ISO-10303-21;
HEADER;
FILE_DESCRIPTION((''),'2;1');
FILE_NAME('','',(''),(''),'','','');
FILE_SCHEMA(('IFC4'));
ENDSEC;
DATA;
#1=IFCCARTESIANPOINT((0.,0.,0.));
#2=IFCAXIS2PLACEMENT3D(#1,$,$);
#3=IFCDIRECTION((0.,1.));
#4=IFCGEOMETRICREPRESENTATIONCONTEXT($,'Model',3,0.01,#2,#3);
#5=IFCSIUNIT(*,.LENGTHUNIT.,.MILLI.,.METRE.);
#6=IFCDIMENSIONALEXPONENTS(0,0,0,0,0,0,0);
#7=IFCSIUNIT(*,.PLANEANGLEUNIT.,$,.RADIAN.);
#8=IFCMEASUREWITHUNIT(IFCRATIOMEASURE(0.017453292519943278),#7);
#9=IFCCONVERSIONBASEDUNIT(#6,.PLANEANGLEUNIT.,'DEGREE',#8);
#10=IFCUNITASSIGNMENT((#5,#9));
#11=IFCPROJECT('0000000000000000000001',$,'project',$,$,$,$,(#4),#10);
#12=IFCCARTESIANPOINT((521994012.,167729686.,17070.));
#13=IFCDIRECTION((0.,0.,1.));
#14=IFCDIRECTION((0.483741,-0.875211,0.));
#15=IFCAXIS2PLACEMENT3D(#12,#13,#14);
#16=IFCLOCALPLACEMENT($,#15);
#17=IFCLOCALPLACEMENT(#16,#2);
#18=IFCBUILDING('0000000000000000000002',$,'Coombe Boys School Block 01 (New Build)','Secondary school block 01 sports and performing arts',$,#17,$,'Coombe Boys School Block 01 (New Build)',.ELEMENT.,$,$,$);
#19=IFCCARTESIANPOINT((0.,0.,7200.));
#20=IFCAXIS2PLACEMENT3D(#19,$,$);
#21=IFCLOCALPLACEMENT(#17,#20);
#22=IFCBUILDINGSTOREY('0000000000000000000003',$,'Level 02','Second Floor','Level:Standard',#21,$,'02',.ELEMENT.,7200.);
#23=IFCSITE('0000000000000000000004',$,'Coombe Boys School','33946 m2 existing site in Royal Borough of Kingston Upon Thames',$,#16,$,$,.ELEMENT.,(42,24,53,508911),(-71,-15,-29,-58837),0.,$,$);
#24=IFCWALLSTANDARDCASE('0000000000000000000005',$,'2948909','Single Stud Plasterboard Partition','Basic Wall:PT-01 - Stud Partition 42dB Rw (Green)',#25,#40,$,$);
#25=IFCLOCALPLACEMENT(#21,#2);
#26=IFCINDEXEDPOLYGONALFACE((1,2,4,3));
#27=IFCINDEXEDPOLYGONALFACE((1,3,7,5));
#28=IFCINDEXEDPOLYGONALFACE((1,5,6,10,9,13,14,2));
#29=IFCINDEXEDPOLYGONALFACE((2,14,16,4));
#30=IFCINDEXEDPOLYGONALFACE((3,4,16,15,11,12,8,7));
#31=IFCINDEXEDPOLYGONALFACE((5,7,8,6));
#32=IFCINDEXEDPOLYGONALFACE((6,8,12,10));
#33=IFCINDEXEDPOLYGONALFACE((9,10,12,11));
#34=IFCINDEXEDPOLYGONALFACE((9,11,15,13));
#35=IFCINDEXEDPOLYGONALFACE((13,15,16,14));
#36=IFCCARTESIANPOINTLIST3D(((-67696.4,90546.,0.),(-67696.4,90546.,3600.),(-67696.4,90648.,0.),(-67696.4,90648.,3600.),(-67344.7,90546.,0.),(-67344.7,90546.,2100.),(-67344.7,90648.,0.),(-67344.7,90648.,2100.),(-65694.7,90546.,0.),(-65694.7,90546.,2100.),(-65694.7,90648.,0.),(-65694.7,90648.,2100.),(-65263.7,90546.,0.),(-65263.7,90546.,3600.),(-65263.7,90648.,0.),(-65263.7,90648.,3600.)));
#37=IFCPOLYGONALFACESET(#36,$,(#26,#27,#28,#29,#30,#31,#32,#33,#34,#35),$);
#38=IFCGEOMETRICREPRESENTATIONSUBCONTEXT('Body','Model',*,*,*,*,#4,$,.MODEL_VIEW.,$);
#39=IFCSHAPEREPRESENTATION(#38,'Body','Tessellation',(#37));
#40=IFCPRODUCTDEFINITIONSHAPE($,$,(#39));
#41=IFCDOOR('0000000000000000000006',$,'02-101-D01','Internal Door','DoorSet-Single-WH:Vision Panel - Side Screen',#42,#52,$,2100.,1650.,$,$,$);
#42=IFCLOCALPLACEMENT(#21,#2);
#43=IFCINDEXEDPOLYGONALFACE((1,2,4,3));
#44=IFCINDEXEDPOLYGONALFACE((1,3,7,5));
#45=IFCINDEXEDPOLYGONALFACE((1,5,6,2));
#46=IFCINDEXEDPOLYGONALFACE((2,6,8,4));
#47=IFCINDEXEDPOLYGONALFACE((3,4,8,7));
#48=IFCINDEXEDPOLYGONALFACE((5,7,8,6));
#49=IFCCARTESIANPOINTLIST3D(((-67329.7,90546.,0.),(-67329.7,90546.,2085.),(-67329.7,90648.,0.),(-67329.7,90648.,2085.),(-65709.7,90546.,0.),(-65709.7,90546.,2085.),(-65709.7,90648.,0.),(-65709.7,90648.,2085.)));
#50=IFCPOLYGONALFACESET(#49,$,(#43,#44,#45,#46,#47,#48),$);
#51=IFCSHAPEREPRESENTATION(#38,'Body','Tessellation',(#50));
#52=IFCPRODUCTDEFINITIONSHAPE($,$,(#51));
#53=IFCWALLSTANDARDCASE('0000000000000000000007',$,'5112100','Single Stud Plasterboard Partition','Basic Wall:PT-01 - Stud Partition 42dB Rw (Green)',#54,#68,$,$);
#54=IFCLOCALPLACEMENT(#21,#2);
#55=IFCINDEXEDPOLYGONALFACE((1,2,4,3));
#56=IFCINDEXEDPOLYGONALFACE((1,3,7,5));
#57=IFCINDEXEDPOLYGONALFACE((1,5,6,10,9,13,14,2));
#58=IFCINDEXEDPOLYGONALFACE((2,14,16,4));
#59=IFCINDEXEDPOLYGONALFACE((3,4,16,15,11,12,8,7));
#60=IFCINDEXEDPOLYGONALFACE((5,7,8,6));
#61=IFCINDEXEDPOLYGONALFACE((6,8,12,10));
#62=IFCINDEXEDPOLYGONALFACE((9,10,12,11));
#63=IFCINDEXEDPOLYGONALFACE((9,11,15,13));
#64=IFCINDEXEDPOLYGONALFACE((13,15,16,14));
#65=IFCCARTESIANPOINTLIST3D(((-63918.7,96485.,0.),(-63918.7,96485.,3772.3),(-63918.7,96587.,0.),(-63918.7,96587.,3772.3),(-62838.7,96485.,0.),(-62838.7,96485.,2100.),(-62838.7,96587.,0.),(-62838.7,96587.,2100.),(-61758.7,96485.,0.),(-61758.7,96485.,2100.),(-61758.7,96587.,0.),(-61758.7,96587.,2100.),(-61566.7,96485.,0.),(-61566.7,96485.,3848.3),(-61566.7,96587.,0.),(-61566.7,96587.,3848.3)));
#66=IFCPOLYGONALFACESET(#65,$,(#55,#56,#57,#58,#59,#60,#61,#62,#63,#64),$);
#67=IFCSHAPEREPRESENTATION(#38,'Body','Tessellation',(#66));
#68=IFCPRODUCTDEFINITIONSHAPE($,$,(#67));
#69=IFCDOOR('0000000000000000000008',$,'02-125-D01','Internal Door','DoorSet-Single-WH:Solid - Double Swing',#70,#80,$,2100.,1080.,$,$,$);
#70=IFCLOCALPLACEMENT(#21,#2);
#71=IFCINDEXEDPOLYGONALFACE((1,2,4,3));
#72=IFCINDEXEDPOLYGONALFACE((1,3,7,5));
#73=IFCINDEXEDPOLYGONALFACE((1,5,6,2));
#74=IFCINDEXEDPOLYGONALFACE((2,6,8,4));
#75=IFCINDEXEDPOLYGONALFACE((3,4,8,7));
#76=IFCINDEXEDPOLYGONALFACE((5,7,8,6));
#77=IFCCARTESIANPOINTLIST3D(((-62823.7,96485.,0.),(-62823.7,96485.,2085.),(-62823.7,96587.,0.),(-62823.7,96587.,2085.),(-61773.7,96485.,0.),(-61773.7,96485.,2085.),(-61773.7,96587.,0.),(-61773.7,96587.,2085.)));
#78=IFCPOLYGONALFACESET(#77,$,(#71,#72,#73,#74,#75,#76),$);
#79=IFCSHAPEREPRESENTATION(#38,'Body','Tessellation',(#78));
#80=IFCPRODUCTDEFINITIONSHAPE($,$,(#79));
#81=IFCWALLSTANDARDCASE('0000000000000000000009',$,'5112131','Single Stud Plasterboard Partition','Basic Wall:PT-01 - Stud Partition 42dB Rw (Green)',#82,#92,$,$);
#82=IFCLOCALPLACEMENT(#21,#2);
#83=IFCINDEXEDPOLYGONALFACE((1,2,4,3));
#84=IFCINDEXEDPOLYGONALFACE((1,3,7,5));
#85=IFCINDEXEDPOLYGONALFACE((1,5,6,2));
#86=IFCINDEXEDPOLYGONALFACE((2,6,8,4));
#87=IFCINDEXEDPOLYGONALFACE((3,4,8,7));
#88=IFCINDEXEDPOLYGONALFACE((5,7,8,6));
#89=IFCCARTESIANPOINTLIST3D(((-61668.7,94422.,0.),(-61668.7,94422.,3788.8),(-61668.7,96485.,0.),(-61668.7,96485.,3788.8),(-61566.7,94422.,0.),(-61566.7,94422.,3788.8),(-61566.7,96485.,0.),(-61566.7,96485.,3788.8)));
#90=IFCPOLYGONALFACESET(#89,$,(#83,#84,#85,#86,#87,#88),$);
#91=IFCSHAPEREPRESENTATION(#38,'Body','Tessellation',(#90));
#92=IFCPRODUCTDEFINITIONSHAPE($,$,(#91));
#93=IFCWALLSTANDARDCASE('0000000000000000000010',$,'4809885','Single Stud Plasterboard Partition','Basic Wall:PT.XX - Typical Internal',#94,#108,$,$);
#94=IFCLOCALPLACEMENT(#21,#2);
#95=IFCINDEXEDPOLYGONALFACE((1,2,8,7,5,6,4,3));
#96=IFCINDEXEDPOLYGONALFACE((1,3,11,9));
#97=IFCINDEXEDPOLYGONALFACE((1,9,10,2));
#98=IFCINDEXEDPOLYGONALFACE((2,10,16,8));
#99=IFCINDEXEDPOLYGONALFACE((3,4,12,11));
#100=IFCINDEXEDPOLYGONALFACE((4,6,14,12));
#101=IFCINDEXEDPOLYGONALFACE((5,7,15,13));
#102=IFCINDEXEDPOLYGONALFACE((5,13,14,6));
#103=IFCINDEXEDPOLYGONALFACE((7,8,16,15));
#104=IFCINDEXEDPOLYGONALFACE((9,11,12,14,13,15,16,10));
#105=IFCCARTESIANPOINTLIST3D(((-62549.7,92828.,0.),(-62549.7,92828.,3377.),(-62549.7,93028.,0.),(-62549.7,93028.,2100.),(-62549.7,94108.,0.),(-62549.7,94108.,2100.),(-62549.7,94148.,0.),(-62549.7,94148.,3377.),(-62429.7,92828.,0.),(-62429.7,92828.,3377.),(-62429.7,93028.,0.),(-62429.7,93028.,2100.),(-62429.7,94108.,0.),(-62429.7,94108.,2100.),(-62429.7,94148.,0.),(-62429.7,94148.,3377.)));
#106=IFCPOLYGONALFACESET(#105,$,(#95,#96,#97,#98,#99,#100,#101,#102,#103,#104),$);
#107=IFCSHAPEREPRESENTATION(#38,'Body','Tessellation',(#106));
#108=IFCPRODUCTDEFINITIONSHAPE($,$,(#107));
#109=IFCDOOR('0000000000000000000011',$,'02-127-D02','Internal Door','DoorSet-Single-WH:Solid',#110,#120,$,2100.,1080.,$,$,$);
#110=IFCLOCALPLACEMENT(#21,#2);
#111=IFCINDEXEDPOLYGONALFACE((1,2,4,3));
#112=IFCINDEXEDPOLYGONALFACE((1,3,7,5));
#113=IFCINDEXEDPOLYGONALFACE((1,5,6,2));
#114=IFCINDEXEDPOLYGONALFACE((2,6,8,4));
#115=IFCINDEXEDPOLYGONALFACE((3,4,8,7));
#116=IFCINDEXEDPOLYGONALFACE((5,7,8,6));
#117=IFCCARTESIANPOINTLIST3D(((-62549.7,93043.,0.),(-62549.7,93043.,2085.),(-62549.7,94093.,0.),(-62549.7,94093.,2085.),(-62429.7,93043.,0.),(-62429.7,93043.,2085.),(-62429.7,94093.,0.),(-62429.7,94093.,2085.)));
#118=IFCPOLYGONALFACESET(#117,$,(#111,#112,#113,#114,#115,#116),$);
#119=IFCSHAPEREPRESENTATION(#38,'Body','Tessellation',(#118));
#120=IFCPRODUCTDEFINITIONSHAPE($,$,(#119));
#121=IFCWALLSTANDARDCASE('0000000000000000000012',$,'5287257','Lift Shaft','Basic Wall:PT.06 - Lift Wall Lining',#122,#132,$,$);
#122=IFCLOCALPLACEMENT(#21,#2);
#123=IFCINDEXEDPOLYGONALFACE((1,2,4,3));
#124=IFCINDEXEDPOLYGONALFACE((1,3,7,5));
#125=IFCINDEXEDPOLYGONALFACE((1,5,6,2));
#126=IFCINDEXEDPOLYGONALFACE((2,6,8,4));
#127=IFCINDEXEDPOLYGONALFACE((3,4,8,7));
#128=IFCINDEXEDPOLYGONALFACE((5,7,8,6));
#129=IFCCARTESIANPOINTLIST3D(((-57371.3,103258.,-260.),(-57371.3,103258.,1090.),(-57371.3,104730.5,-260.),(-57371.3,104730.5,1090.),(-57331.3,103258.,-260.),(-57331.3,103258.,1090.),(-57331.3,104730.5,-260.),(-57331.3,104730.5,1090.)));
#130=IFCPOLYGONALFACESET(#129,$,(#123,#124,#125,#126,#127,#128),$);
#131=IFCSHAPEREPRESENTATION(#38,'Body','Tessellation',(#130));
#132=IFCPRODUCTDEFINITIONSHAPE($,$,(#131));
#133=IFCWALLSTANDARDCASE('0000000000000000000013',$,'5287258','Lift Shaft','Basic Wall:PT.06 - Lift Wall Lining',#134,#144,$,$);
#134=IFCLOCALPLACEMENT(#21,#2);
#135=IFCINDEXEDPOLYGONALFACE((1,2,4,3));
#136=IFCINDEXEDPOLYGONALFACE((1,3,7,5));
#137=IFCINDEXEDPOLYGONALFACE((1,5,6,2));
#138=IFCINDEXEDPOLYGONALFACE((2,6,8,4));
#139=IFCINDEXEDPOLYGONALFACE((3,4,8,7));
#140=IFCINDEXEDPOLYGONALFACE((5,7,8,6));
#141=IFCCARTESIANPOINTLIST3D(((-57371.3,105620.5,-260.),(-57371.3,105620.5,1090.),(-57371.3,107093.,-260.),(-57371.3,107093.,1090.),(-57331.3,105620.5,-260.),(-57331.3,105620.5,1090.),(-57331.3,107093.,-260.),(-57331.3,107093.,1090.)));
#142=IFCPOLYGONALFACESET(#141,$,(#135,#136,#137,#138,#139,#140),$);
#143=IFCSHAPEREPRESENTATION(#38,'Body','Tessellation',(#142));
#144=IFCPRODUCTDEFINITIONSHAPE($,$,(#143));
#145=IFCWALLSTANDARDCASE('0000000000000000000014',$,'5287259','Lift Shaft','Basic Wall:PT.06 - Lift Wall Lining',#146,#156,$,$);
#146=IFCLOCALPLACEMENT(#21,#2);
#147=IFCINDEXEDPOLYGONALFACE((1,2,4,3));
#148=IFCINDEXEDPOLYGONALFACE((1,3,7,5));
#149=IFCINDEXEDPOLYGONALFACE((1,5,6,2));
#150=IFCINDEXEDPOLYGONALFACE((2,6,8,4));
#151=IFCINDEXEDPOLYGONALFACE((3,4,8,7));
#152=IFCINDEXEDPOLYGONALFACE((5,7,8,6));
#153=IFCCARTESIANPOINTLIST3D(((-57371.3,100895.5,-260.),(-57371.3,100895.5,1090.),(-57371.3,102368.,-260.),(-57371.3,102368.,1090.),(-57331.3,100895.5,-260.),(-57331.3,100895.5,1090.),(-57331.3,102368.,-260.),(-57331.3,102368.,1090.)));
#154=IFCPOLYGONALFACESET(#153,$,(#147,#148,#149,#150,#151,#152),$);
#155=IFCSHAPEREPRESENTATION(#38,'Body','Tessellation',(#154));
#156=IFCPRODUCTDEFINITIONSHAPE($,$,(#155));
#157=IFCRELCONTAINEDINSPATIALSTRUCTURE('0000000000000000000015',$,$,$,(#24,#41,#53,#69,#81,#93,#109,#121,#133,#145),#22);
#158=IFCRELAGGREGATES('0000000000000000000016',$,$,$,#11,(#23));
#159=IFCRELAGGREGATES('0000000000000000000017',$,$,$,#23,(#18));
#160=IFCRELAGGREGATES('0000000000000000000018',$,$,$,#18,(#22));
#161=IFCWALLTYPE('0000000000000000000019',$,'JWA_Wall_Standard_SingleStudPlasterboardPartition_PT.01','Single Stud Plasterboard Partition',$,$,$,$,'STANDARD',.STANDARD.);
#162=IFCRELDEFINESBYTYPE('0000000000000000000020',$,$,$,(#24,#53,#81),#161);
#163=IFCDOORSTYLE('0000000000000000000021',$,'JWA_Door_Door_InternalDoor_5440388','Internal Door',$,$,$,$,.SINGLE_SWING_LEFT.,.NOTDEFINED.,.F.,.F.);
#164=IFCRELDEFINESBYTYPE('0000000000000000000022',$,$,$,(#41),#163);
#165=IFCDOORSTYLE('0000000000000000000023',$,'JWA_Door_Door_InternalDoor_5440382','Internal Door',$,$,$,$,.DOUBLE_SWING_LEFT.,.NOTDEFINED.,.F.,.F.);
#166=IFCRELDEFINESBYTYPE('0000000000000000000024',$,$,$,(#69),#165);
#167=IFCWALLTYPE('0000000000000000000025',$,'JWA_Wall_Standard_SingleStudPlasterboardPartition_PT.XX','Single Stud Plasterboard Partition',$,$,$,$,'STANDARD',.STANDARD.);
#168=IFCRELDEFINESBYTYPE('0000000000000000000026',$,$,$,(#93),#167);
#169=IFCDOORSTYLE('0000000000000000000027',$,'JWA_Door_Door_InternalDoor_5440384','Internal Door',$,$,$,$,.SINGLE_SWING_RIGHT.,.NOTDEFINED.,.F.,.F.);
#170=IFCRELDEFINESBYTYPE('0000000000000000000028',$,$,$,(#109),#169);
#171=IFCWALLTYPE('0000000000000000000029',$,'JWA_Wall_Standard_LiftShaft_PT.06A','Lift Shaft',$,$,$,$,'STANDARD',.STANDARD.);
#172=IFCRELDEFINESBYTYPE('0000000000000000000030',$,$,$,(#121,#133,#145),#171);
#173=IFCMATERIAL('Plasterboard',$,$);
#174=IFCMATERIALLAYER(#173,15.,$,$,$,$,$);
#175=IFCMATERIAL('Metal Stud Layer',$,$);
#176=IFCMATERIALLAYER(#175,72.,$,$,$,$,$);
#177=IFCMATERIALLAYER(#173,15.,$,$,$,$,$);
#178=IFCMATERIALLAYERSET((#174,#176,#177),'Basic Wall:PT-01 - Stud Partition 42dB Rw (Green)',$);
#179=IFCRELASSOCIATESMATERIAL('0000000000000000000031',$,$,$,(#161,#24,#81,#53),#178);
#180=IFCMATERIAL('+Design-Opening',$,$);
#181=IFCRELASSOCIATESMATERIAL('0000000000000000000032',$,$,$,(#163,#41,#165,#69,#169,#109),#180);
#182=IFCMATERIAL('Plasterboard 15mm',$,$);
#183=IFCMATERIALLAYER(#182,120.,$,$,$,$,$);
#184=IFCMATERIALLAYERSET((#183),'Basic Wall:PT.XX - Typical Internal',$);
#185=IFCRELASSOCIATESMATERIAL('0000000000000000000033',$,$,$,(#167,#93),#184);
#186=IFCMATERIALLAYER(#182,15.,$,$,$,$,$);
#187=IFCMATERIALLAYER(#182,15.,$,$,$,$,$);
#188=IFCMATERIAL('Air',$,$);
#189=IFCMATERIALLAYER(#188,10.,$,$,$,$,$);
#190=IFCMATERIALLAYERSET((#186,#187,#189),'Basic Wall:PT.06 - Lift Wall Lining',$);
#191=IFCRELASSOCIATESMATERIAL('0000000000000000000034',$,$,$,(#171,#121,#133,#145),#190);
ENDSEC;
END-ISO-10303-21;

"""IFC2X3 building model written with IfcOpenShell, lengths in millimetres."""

from ifc_helpers import new_model, entity, si_unit, converted_unit, direction, frame, frame_2d, origin, origin_2d_with_axis, place, context, subcontext, project, spatial, polyline, rectangle, extrude, clip, bounded_halfspace, source, transform, mapped, material, layer, layer_set, layer_usage, type_object, type_shapes, element, fill, save


model = new_model("IFC2X3")

# Units and contexts
model_context = context("Model", 3, precision=0.01, world=origin(), true_north=direction((0.0, 1.0)))
body_context = subcontext(model_context, "Body", "Model", "MODEL_VIEW")
ifc_project = project(units=[si_unit("LENGTHUNIT", "METRE", prefix="MILLI"), converted_unit("PLANEANGLEUNIT", "DEGREE", entity("IfcRatioMeasure", 0.017453292519943278), si_unit("PLANEANGLEUNIT", "RADIAN"), dimensions=[0, 0, 0, 0, 0, 0, 0])], contexts=[model_context])

# Site, building, storey
site_placement = place(None, frame((521994012.0, 167729686.0, 17070.0), z_axis=(0.0, 0.0, 1.0), x_axis=(0.483741, -0.875211, 0.0)))
site = spatial("IfcSite", under=ifc_project, at=site_placement, Name="Coombe Boys School", Description="33946 m2 existing site in Royal Borough of Kingston Upon Thames", CompositionType="ELEMENT", RefLatitude=(42, 24, 53, 508911), RefLongitude=(-71, -15, -29, -58837), RefElevation=0.0)
building_placement = place(site_placement, origin())
building = spatial("IfcBuilding", under=site, at=building_placement, Name="Coombe Boys School Block 01 (New Build)", Description="Secondary school block 01 sports and performing arts", LongName="Coombe Boys School Block 01 (New Build)", CompositionType="ELEMENT")
storey_placement = place(building_placement, frame((0.0, 0.0, 7200.0)))
storey = spatial("IfcBuildingStorey", under=building, at=storey_placement, Name="Level 02", Description="Second Floor", ObjectType="Level:Standard", LongName="02", CompositionType="ELEMENT", Elevation=7200.0)

# Walls, openings, doors
ifc_material_1 = material(Name="Plasterboard")
ifc_layer_1 = layer(ifc_material_1, 15.0)
ifc_material_2 = material(Name="Metal Stud Layer")
ifc_layer_2 = layer(ifc_material_2, 72.0)
ifc_layer_3 = layer(ifc_material_1, 15.0)
ifc_layer_set_1 = layer_set([ifc_layer_1, ifc_layer_2, ifc_layer_3], Name="Basic Wall:PT-01 - Stud Partition 42dB Rw (Green)")
ifc_layer_usage_1 = layer_usage(ifc_layer_set_1, "AXIS2", "NEGATIVE", 51.0)
wall_type_1 = type_object("IfcWallType", Name="JWA_Wall_Standard_SingleStudPlasterboardPartition_PT.01", Description="Single Stud Plasterboard Partition", ElementType="STANDARD", PredefinedType="STANDARD", material=ifc_layer_set_1)
wall_1_placement = place(storey_placement, frame((-65263.7, 90597.0, 0.0), z_axis=(0.0, 0.0, 1.0), x_axis=(-1.0, 0.0, 0.0)))
wall_1 = element("IfcWallStandardCase", 1, at=wall_1_placement, inside=storey, type_object=wall_type_1, material=ifc_layer_usage_1, Name="2948909", Description="Single Stud Plasterboard Partition", ObjectType="Basic Wall:PT-01 - Stud Partition 42dB Rw (Green)", context=body_context, shape_type="SweptSolid", body=[
    extrude(rectangle(XDim=2432.7, YDim=102.0, at=frame_2d((1216.3, 0.0), x_axis=(-1.0, 0.0))), origin(), (0.0, 0.0, 1.0), 3600.0),
])
opening_1_placement = place(wall_1_placement, frame((-65263.7, 90597.0, 0.0), z_axis=(0.0, 0.0, 1.0), x_axis=(-1.0, 0.0, 0.0)))
opening_1 = element("IfcOpeningElement", 2, at=opening_1_placement, cuts=wall_1, ObjectType="Opening", context=body_context, shape_type="SweptSolid", body=[
    extrude(rectangle(XDim=2100.0, YDim=1650.0, at=frame_2d((0.0, 0.0), x_axis=(0.0, 1.0))), frame((-66519.7, 90648.0, 1050.0), z_axis=(0.0, -1.0, 0.0), x_axis=(-1.0, 0.0, 0.0)), (0.0, 0.0, 1.0), 102.0),
])
ifc_material_3 = material(Name="+Design-Opening")
door_style_1 = type_object("IfcDoorStyle", Name="JWA_Door_Door_InternalDoor_5440388", Description="Internal Door", ConstructionType="NOTDEFINED", OperationType="SINGLE_SWING_LEFT", ParameterTakesPrecedence=False, Sizeable=False, material=ifc_material_3)
shared_shape_1 = source(origin(), body_context, "Body", "SweptSolid", [
    extrude(rectangle(XDim=1620.0, YDim=102.0, at=origin_2d_with_axis()), frame((-160.0, 0.0, 0.0), z_axis=(0.0, 0.0, 1.0), x_axis=(-1.0, 0.0, 0.0)), (0.0, 0.0, 1.0), 2085.0),
])
type_shapes(door_style_1, [shared_shape_1])
door_1_placement = place(opening_1_placement, frame((-66359.7, 90597.0, 0.0)))
door_1 = element("IfcDoor", 3, at=door_1_placement, inside=storey, type_object=door_style_1, material=ifc_material_3, Name="02-101-D01", Description="Internal Door", ObjectType="DoorSet-Single-WH:Vision Panel - Side Screen", OverallHeight=2100.0, OverallWidth=1650.0, context=body_context, shape_type="MappedRepresentation", body=[
    mapped(shared_shape_1, transform((0.0, 0.0, 0.0), scale=1.0)),
])
fill(opening_1, door_1)
ifc_layer_usage_2 = layer_usage(ifc_layer_set_1, "AXIS2", "POSITIVE", -51.0)
wall_2_placement = place(storey_placement, frame((-61566.7, 96536.0, 0.0), z_axis=(0.0, 0.0, 1.0), x_axis=(-1.0, 0.0, 0.0)))
wall_2 = element("IfcWallStandardCase", 4, at=wall_2_placement, inside=storey, type_object=wall_type_1, material=ifc_layer_usage_2, Name="5112100", Description="Single Stud Plasterboard Partition", ObjectType="Basic Wall:PT-01 - Stud Partition 42dB Rw (Green)", context=body_context, shape_type="Clipping", body=[
    clip(extrude(rectangle(XDim=2352.0, YDim=102.0, at=frame_2d((1176.0, 0.0), x_axis=(1.0, 0.0))), origin(), (0.0, 0.0, 1.0), 3848.3), bounded_halfspace(frame((0.0, -51.0, 3848.3), z_axis=(0.032283, 0.0, 0.999479), x_axis=(0.0, 1.0, 0.0)), False, frame((0.0, -51.0, 3848.3)), polyline([(0.0, 0.0), (2352.0, 0.0), (2352.0, 102.0), (0.0, 102.0), (0.0, 0.0)]))),
])
opening_2_placement = place(wall_2_placement, frame((-61566.7, 96536.0, 0.0), z_axis=(0.0, 0.0, 1.0), x_axis=(-1.0, 0.0, 0.0)))
opening_2 = element("IfcOpeningElement", 5, at=opening_2_placement, cuts=wall_2, ObjectType="Opening", context=body_context, shape_type="SweptSolid", body=[
    extrude(rectangle(XDim=2100.0, YDim=1080.0, at=frame_2d((0.0, 0.0), x_axis=(0.0, 1.0))), frame((-62298.7, 96587.0, 1050.0), z_axis=(0.0, -1.0, 0.0), x_axis=(-1.0, 0.0, 0.0)), (0.0, 0.0, 1.0), 102.0),
])
door_style_2 = type_object("IfcDoorStyle", Name="JWA_Door_Door_InternalDoor_5440382", Description="Internal Door", ConstructionType="NOTDEFINED", OperationType="DOUBLE_SWING_LEFT", ParameterTakesPrecedence=False, Sizeable=False, material=ifc_material_3)
shared_shape_2 = source(origin(), body_context, "Body", "SweptSolid", [
    extrude(rectangle(XDim=1050.0, YDim=102.0, at=origin_2d_with_axis()), frame((125.0, 0.0, 0.0), z_axis=(0.0, 0.0, 1.0), x_axis=(-1.0, 0.0, 0.0)), (0.0, 0.0, 1.0), 2085.0),
])
type_shapes(door_style_2, [shared_shape_2])
door_2_placement = place(opening_2_placement, frame((-62423.7, 96536.0, 0.0)))
door_2 = element("IfcDoor", 6, at=door_2_placement, inside=storey, type_object=door_style_2, material=ifc_material_3, Name="02-125-D01", Description="Internal Door", ObjectType="DoorSet-Single-WH:Solid - Double Swing", OverallHeight=2100.0, OverallWidth=1080.0, context=body_context, shape_type="MappedRepresentation", body=[
    mapped(shared_shape_2, transform((0.0, 0.0, 0.0), scale=1.0)),
])
fill(opening_2, door_2)

# Wall
wall_3_placement = place(storey_placement, frame((-61617.7, 96485.0, 0.0), z_axis=(0.0, 0.0, 1.0), x_axis=(0.0, -1.0, 0.0)))
element("IfcWallStandardCase", 7, at=wall_3_placement, inside=storey, type_object=wall_type_1, material=ifc_layer_usage_1, Name="5112131", Description="Single Stud Plasterboard Partition", ObjectType="Basic Wall:PT-01 - Stud Partition 42dB Rw (Green)", context=body_context, shape_type="SweptSolid", body=[
    extrude(rectangle(XDim=2063.0, YDim=102.0, at=frame_2d((1031.5, 0.0), x_axis=(-1.0, 0.0))), origin(), (0.0, 0.0, 1.0), 3788.8),
])

# Wall, opening, door
ifc_material_4 = material(Name="Plasterboard 15mm")
ifc_layer_4 = layer(ifc_material_4, 120.0)
ifc_layer_set_2 = layer_set([ifc_layer_4], Name="Basic Wall:PT.XX - Typical Internal")
ifc_layer_usage_3 = layer_usage(ifc_layer_set_2, "AXIS2", "NEGATIVE", 60.0)
wall_type_2 = type_object("IfcWallType", Name="JWA_Wall_Standard_SingleStudPlasterboardPartition_PT.XX", Description="Single Stud Plasterboard Partition", ElementType="STANDARD", PredefinedType="STANDARD", material=ifc_layer_set_2)
wall_4_placement = place(storey_placement, frame((-62489.7, 94148.0, 0.0), z_axis=(0.0, 0.0, 1.0), x_axis=(0.0, -1.0, 0.0)))
wall_4 = element("IfcWallStandardCase", 8, at=wall_4_placement, inside=storey, type_object=wall_type_2, material=ifc_layer_usage_3, Name="4809885", Description="Single Stud Plasterboard Partition", ObjectType="Basic Wall:PT.XX - Typical Internal", context=body_context, shape_type="SweptSolid", body=[
    extrude(rectangle(XDim=1320.0, YDim=120.0, at=frame_2d((660.0, 0.0), x_axis=(-1.0, 0.0))), origin(), (0.0, 0.0, 1.0), 3377.0),
])
opening_3_placement = place(wall_4_placement, frame((94148.0, 62489.7, 0.0), z_axis=(0.0, 0.0, 1.0), x_axis=(0.0, 1.0, 0.0)))
opening_3 = element("IfcOpeningElement", 9, at=opening_3_placement, cuts=wall_4, ObjectType="Opening", context=body_context, shape_type="SweptSolid", body=[
    extrude(rectangle(XDim=2100.0, YDim=1080.0, at=frame_2d((0.0, 0.0), x_axis=(0.0, 1.0))), frame((-62549.7, 93568.0, 1050.0), z_axis=(1.0, 0.0, 0.0), x_axis=(0.0, -1.0, 0.0)), (0.0, 0.0, 1.0), 120.0),
])
door_style_3 = type_object("IfcDoorStyle", Name="JWA_Door_Door_InternalDoor_5440384", Description="Internal Door", ConstructionType="NOTDEFINED", OperationType="SINGLE_SWING_RIGHT", ParameterTakesPrecedence=False, Sizeable=False, material=ifc_material_3)
shared_shape_3 = source(origin(), body_context, "Body", "SweptSolid", [
    extrude(rectangle(XDim=120.0, YDim=1050.0, at=origin_2d_with_axis()), frame((125.0, 0.0, 0.0), z_axis=(0.0, 0.0, 1.0), x_axis=(0.0, 1.0, 0.0)), (0.0, 0.0, 1.0), 2085.0),
])
type_shapes(door_style_3, [shared_shape_3])
door_3_placement = place(opening_3_placement, frame((-62489.7, 93443.0, 0.0), z_axis=(0.0, 0.0, 1.0), x_axis=(0.0, 1.0, 0.0)))
door_3 = element("IfcDoor", 10, at=door_3_placement, inside=storey, type_object=door_style_3, material=ifc_material_3, Name="02-127-D02", Description="Internal Door", ObjectType="DoorSet-Single-WH:Solid", OverallHeight=2100.0, OverallWidth=1080.0, context=body_context, shape_type="MappedRepresentation", body=[
    mapped(shared_shape_3, transform((0.0, 0.0, 0.0), scale=1.0)),
])
fill(opening_3, door_3)

# Walls
ifc_layer_5 = layer(ifc_material_4, 15.0)
ifc_layer_6 = layer(ifc_material_4, 15.0)
ifc_material_5 = material(Name="Air")
ifc_layer_7 = layer(ifc_material_5, 10.0)
ifc_layer_set_3 = layer_set([ifc_layer_5, ifc_layer_6, ifc_layer_7], Name="Basic Wall:PT.06 - Lift Wall Lining")
ifc_layer_usage_4 = layer_usage(ifc_layer_set_3, "AXIS2", "NEGATIVE", 20.0)
wall_type_3 = type_object("IfcWallType", Name="JWA_Wall_Standard_LiftShaft_PT.06A", Description="Lift Shaft", ElementType="STANDARD", PredefinedType="STANDARD", material=ifc_layer_set_3)
wall_5_placement = place(storey_placement, frame((-57351.3, 103258.0, -260.0), z_axis=(0.0, 0.0, 1.0), x_axis=(0.0, 1.0, 0.0)))
element("IfcWallStandardCase", 11, at=wall_5_placement, inside=storey, type_object=wall_type_3, material=ifc_layer_usage_4, Name="5287257", Description="Lift Shaft", ObjectType="Basic Wall:PT.06 - Lift Wall Lining", context=body_context, shape_type="SweptSolid", body=[
    extrude(rectangle(XDim=1472.5, YDim=40.0, at=frame_2d((736.2, 0.0), x_axis=(-1.0, 0.0))), origin(), (0.0, 0.0, 1.0), 1350.0),
])
wall_6_placement = place(storey_placement, frame((-57351.3, 105620.5, -260.0), z_axis=(0.0, 0.0, 1.0), x_axis=(0.0, 1.0, 0.0)))
element("IfcWallStandardCase", 12, at=wall_6_placement, inside=storey, type_object=wall_type_3, material=ifc_layer_usage_4, Name="5287258", Description="Lift Shaft", ObjectType="Basic Wall:PT.06 - Lift Wall Lining", context=body_context, shape_type="SweptSolid", body=[
    extrude(rectangle(XDim=1472.5, YDim=40.0, at=frame_2d((736.3, 0.0), x_axis=(-1.0, 0.0))), origin(), (0.0, 0.0, 1.0), 1350.0),
])
wall_7_placement = place(storey_placement, frame((-57351.3, 100895.5, -260.0), z_axis=(0.0, 0.0, 1.0), x_axis=(0.0, 1.0, 0.0)))
element("IfcWallStandardCase", 13, at=wall_7_placement, inside=storey, type_object=wall_type_3, material=ifc_layer_usage_4, Name="5287259", Description="Lift Shaft", ObjectType="Basic Wall:PT.06 - Lift Wall Lining", context=body_context, shape_type="SweptSolid", body=[
    extrude(rectangle(XDim=1472.5, YDim=40.0, at=frame_2d((736.2, 0.0), x_axis=(-1.0, 0.0))), origin(), (0.0, 0.0, 1.0), 1350.0),
])

save(model, "model.ifc")
